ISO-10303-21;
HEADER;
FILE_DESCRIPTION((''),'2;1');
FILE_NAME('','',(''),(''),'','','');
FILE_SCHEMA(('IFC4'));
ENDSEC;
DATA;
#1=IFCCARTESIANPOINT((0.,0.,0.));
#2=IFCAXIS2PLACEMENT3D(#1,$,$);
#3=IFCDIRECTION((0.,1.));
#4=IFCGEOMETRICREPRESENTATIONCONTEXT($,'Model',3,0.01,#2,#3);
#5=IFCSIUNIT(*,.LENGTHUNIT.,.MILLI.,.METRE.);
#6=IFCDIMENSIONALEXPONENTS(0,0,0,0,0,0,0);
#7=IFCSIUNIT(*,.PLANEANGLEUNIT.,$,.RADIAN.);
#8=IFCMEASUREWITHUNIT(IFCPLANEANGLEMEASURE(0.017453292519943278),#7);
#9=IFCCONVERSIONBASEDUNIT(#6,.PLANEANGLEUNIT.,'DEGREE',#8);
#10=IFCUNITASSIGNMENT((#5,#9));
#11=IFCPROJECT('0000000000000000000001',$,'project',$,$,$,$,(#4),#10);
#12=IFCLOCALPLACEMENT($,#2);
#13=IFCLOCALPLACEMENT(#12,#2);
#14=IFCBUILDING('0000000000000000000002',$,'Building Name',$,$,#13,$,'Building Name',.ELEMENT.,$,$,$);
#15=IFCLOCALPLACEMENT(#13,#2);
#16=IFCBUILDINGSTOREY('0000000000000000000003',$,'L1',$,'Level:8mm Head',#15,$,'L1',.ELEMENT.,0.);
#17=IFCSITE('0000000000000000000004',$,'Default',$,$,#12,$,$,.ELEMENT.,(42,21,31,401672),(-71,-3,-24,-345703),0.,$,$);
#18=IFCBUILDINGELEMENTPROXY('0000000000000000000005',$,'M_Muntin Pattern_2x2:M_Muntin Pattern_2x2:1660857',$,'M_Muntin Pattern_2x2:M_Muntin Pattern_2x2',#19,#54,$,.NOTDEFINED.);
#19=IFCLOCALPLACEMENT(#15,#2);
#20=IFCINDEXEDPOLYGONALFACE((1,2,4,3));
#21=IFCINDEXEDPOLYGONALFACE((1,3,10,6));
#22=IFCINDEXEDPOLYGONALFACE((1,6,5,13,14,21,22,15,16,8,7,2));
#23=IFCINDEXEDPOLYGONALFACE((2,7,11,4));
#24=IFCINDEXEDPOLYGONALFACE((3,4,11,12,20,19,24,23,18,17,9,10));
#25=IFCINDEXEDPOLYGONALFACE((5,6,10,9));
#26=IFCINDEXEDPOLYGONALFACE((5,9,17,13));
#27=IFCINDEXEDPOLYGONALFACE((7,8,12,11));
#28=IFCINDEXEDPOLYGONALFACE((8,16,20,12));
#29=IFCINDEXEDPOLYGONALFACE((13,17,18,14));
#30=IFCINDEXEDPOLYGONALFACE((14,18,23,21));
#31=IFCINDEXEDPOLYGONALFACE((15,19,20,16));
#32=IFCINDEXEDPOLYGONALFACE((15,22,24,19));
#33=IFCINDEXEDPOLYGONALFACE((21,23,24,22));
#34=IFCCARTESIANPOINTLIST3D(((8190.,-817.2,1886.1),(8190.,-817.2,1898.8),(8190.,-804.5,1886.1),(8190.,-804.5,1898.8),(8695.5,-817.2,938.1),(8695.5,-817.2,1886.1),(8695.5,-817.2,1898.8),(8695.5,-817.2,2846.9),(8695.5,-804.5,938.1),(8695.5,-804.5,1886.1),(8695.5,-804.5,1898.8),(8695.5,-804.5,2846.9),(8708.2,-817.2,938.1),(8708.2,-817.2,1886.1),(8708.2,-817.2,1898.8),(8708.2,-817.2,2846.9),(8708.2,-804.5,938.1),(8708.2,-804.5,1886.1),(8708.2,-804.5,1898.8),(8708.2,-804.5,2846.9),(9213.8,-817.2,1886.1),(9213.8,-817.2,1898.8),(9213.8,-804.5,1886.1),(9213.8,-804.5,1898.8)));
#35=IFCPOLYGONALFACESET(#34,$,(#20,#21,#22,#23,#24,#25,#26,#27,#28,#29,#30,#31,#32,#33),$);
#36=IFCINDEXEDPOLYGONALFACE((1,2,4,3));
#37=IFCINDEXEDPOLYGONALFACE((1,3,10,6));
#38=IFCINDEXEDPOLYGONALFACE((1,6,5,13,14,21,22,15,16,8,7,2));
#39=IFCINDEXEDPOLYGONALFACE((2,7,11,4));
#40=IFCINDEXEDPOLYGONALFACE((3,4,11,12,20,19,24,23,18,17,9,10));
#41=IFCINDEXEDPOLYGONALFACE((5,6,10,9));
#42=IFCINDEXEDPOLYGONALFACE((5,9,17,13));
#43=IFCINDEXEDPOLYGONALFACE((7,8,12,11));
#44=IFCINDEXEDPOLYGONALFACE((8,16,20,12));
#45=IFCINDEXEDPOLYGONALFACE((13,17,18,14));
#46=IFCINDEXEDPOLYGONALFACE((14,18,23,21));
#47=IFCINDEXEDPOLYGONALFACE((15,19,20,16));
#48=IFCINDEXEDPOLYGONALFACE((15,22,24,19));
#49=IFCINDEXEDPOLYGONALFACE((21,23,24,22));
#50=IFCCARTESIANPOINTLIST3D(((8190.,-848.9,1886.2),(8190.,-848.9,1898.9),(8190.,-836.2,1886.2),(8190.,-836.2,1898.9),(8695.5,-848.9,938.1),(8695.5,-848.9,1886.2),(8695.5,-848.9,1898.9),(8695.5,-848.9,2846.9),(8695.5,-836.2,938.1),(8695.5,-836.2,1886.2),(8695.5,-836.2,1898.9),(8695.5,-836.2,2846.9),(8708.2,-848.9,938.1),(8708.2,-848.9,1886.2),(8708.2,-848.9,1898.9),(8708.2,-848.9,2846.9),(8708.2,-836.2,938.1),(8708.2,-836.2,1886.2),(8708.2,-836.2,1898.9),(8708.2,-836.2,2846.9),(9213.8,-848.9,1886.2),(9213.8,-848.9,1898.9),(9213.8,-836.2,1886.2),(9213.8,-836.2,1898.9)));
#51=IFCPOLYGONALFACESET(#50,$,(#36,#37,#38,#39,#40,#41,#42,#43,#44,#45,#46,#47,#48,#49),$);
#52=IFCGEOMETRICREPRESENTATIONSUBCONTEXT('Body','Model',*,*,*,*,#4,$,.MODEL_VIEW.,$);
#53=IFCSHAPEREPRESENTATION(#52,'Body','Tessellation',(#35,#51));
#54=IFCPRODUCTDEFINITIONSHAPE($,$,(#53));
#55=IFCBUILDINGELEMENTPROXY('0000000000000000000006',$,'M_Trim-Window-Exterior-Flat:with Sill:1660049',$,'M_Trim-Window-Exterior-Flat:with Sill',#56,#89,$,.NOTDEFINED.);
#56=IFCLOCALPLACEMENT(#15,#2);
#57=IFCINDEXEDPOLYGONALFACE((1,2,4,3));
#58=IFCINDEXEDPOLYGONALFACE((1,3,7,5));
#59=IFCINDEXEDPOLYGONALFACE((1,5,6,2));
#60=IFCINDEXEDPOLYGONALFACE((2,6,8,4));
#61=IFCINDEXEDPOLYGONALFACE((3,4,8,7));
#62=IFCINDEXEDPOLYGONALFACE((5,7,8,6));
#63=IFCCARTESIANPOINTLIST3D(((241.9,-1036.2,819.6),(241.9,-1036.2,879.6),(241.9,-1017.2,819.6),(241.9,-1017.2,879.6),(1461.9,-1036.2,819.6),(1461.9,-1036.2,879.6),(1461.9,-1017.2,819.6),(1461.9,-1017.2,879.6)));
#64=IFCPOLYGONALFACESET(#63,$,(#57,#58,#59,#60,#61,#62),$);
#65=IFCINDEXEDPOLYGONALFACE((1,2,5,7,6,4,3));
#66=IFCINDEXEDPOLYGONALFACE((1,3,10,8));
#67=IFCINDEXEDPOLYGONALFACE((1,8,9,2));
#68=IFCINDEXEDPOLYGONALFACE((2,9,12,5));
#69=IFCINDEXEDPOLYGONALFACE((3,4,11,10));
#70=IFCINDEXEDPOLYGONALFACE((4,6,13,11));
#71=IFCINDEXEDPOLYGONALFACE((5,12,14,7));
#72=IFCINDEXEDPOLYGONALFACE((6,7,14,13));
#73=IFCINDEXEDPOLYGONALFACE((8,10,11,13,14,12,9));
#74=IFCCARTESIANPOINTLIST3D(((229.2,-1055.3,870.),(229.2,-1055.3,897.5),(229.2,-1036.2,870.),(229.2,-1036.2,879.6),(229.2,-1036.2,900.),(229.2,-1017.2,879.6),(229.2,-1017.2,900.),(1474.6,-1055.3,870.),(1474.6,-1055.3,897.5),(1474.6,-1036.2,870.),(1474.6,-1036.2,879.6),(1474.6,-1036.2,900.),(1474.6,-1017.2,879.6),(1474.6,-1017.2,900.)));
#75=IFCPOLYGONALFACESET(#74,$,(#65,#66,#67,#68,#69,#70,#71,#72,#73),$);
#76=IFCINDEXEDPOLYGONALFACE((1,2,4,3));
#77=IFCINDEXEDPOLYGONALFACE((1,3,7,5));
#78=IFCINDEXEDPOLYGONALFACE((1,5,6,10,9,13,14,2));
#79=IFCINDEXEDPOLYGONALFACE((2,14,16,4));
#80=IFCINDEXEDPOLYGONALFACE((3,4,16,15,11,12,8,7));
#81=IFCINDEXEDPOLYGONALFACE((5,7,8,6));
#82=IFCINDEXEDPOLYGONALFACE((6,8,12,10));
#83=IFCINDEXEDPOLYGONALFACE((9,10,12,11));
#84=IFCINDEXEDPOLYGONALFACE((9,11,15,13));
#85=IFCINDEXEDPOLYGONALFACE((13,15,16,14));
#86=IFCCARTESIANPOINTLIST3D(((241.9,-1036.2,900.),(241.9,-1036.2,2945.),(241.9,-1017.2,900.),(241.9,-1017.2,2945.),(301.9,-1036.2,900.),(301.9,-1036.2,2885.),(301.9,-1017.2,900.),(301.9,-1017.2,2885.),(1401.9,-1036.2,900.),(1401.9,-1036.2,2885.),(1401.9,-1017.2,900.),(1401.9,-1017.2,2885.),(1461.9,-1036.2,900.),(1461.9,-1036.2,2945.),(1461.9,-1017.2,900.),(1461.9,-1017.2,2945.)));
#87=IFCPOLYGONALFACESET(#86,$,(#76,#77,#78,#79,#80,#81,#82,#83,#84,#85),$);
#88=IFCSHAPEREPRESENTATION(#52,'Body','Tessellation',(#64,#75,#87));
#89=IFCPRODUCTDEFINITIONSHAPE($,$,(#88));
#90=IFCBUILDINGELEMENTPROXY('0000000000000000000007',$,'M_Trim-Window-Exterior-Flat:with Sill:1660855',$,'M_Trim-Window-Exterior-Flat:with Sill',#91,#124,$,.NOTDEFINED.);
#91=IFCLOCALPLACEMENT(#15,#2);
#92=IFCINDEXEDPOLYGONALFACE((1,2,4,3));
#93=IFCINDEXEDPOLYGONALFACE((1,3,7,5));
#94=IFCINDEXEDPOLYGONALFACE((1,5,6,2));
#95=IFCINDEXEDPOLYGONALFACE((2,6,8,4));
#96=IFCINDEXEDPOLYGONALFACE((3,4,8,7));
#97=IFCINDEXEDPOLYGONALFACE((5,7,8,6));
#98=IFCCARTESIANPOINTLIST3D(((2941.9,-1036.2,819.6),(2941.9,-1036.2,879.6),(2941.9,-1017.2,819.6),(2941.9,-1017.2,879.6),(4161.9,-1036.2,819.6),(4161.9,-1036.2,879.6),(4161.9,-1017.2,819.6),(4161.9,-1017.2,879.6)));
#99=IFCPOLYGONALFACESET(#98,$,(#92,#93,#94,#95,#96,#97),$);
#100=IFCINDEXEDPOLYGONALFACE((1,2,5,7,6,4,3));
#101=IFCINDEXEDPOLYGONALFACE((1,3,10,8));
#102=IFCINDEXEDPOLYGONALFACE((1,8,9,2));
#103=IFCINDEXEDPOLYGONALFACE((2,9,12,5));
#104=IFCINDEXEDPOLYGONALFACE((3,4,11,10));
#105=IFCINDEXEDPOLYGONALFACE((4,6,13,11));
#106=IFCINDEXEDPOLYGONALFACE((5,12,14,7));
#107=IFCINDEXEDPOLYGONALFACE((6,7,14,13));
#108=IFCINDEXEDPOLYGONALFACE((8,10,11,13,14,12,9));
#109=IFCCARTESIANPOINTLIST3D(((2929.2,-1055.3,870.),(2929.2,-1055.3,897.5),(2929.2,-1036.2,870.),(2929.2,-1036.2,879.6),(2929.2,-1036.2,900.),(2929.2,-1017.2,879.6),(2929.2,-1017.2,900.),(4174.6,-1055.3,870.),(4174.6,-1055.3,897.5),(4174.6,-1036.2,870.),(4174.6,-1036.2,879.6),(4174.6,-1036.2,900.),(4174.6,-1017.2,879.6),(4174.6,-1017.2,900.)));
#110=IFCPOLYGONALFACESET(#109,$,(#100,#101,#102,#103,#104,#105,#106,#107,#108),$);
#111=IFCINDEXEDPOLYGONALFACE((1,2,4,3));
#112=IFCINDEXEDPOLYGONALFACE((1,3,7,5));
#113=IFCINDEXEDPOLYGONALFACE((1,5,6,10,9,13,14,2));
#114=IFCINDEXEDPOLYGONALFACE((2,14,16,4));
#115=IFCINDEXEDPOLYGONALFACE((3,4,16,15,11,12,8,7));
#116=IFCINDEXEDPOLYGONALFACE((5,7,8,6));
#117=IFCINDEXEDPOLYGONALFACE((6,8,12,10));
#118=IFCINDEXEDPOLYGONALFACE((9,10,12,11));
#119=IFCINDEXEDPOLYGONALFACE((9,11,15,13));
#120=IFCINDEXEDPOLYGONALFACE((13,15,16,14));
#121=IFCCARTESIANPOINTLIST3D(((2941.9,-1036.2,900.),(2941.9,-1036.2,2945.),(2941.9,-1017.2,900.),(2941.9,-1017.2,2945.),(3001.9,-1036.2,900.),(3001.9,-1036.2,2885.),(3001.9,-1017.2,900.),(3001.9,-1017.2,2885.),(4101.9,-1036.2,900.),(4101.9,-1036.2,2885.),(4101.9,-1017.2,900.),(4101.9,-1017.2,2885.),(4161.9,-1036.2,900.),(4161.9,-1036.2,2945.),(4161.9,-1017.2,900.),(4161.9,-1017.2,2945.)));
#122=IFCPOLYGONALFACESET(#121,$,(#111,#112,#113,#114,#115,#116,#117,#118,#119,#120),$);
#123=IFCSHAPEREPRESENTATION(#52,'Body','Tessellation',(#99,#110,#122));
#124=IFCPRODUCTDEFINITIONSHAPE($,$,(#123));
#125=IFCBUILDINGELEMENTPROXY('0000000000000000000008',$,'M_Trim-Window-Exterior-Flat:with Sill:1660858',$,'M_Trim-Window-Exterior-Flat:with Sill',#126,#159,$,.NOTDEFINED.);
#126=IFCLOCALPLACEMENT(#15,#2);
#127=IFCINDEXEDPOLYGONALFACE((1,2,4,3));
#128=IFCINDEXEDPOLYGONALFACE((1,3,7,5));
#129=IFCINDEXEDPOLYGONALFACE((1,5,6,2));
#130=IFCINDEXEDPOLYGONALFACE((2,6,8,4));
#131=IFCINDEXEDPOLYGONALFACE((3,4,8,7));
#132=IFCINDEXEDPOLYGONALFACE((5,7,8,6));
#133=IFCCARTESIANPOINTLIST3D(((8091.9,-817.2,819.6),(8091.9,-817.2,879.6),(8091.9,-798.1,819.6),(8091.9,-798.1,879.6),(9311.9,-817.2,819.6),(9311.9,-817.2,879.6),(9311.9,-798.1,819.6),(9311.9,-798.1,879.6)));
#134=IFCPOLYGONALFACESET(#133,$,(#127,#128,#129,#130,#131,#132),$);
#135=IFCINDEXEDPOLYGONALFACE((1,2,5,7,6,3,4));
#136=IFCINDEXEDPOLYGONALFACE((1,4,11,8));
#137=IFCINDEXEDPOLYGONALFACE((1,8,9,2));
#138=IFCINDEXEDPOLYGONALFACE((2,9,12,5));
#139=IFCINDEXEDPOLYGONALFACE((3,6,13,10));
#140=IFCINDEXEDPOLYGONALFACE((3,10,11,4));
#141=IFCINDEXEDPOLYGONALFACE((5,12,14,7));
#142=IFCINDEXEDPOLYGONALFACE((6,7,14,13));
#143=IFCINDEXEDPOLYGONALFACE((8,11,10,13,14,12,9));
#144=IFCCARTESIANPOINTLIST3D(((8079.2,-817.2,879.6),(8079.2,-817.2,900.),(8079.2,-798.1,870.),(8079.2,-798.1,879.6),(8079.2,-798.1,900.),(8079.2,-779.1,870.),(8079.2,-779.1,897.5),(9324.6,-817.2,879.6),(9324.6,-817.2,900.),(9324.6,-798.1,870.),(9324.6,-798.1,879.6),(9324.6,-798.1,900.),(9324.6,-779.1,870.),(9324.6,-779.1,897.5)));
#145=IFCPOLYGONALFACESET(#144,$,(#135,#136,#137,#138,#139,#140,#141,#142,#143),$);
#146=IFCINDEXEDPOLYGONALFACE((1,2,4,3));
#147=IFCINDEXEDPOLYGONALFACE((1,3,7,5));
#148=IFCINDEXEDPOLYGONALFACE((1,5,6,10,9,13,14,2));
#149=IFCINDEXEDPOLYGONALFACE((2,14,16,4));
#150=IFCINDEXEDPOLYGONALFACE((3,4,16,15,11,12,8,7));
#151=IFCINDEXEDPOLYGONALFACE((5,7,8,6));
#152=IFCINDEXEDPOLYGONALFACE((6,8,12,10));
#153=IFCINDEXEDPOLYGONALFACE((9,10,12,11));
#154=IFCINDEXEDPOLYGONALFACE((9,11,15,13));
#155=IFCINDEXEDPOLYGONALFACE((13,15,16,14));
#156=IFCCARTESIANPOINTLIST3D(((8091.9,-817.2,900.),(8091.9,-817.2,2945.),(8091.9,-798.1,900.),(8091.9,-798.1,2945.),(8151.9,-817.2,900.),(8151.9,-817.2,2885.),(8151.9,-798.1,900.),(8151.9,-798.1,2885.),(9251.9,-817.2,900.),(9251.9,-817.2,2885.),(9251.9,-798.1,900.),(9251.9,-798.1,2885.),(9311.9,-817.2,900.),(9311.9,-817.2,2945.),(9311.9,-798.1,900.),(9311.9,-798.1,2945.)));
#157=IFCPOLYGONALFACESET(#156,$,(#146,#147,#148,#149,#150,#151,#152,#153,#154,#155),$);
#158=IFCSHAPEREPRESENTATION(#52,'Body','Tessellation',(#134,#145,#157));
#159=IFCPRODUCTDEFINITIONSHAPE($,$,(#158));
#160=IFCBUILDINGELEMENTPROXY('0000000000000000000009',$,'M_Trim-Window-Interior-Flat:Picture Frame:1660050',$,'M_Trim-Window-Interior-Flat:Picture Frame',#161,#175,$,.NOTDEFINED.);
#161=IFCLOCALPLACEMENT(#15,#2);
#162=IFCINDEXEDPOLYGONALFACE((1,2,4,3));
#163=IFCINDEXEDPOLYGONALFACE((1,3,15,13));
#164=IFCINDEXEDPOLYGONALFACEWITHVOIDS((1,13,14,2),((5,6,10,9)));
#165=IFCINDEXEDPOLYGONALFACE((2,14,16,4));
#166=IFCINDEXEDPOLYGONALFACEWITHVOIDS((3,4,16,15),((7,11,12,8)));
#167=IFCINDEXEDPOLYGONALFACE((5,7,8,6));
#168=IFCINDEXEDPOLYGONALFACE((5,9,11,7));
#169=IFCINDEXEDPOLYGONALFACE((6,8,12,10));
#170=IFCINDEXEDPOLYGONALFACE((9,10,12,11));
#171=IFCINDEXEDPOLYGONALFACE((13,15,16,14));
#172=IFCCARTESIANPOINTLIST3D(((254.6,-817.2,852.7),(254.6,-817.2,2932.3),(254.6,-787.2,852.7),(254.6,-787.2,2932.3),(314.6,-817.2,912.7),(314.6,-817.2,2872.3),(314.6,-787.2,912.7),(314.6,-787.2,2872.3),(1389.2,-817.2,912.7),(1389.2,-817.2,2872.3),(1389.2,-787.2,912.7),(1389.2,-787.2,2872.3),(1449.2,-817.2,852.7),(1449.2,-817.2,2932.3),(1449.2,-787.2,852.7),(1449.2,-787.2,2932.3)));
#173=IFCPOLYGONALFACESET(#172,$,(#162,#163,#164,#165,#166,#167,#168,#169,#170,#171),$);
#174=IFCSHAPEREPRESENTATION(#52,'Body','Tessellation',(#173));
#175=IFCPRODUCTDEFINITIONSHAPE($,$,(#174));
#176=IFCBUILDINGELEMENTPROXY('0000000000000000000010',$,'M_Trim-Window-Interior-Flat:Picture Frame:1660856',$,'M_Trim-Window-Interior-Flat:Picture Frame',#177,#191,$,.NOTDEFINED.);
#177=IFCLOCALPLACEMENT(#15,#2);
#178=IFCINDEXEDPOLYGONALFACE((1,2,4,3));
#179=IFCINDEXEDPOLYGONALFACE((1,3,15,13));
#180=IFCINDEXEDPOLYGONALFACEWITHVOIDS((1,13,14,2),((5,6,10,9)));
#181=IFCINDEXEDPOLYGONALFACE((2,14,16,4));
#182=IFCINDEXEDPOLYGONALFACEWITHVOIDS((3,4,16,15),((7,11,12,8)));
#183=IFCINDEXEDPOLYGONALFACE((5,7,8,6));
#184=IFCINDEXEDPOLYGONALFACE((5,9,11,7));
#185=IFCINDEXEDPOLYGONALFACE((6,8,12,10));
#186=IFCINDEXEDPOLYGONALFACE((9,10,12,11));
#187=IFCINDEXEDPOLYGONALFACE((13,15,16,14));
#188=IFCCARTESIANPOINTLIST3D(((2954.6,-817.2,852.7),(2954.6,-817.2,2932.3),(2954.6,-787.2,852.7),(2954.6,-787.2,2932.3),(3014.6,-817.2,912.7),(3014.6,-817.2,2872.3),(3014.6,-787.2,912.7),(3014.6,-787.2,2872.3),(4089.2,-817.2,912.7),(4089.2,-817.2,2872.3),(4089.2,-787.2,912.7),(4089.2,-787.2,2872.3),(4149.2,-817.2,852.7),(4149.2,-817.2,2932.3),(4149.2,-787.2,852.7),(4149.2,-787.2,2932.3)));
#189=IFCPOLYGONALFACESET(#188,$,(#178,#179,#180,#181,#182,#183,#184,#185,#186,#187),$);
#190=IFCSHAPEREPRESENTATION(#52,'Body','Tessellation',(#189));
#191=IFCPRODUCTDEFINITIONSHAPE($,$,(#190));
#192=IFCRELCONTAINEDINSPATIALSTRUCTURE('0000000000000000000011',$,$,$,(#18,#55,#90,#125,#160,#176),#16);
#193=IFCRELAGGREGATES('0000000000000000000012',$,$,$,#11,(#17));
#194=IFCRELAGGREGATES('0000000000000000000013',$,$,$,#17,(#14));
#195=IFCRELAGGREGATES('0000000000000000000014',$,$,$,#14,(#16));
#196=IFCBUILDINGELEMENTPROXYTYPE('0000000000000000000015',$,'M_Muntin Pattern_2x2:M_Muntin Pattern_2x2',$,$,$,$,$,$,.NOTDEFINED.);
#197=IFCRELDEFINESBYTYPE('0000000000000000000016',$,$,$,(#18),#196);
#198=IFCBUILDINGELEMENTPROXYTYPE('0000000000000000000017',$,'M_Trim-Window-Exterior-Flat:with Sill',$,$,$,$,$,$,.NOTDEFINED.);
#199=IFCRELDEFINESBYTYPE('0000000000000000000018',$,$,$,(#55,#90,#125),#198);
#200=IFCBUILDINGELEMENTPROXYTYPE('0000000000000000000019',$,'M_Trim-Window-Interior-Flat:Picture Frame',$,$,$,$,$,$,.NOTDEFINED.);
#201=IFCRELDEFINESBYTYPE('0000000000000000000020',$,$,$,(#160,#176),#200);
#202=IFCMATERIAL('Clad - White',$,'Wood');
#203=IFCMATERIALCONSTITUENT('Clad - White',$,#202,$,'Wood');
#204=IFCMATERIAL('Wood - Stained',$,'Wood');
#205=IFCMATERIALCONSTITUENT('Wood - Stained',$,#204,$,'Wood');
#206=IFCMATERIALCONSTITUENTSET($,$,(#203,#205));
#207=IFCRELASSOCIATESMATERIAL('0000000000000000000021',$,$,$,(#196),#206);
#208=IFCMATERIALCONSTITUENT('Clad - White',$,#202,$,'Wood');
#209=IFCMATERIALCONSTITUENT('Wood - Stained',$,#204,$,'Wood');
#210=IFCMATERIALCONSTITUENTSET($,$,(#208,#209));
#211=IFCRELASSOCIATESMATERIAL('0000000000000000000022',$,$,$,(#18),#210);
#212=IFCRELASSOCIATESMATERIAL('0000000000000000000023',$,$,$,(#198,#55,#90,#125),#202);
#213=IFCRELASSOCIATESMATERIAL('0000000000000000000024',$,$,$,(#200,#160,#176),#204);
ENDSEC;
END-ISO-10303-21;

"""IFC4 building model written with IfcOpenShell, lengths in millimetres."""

from ifc_helpers import new_model, entity, si_unit, converted_unit, direction, frame, origin, place, context, subcontext, project, spatial, indexed_curve, outline, extrude, source, transform, mapped, material, constituent, constituent_set, type_object, type_shapes, element, save


model = new_model("IFC4")

# Units and contexts
model_context = context("Model", 3, precision=0.01, world=origin(), true_north=direction((0.0, 1.0)))
body_context = subcontext(model_context, "Body", "Model", "MODEL_VIEW")
ifc_project = project(units=[si_unit("LENGTHUNIT", "METRE", prefix="MILLI"), converted_unit("PLANEANGLEUNIT", "DEGREE", entity("IfcPlaneAngleMeasure", 0.017453292519943278), si_unit("PLANEANGLEUNIT", "RADIAN"), dimensions=[0, 0, 0, 0, 0, 0, 0])], contexts=[model_context])

# Site, building, storey
site_placement = place(None, origin())
site = spatial("IfcSite", under=ifc_project, at=site_placement, Name="Default", CompositionType="ELEMENT", RefLatitude=(42, 21, 31, 401672), RefLongitude=(-71, -3, -24, -345703), RefElevation=0.0)
building_placement = place(site_placement, origin())
building = spatial("IfcBuilding", under=site, at=building_placement, Name="Building Name", LongName="Building Name", CompositionType="ELEMENT")
storey_placement = place(building_placement, origin())
storey = spatial("IfcBuildingStorey", under=building, at=storey_placement, Name="L1", ObjectType="Level:8mm Head", LongName="L1", CompositionType="ELEMENT", Elevation=0.0)

# Building element proxies
ifc_material_1 = material(Name="Clad - White", Category="Wood")
ifc_material_2 = material(Name="Wood - Stained", Category="Wood")
ifc_constituent_1 = constituent(ifc_material_1, Name="Clad - White", Category="Wood")
ifc_constituent_2 = constituent(ifc_material_2, Name="Wood - Stained", Category="Wood")
ifc_constituent_set_1 = constituent_set(constituents=[ifc_constituent_1, ifc_constituent_2])
building_element_proxy_type_1 = type_object("IfcBuildingElementProxyType", Name="M_Muntin Pattern_2x2:M_Muntin Pattern_2x2", PredefinedType="NOTDEFINED", material=ifc_constituent_set_1)
shared_shape_1 = source(origin(), body_context, "Body", "SweptSolid", [
    extrude(outline(indexed_curve([(6.4, -6.4), (954.4, -6.4), (954.4, 6.3), (6.4, 6.3), (6.4, 511.9), (-6.3, 511.9), (-6.3, 6.3), (-954.4, 6.3), (-954.4, -6.4), (-6.3, -6.4), (-6.3, -511.9), (6.4, -511.9), (6.4, -6.4)], self_intersect=False)), frame((0.0, -22.2, 954.4), z_axis=(0.0, 1.0, 0.0), x_axis=(0.0, 0.0, 1.0)), (0.0, 0.0, 1.0), 12.7),
    extrude(outline(indexed_curve([(6.4, -6.4), (954.4, -6.4), (954.4, 6.3), (6.4, 6.3), (6.4, 511.9), (-6.3, 511.9), (-6.3, 6.3), (-954.4, 6.3), (-954.4, -6.4), (-6.3, -6.4), (-6.3, -511.9), (6.4, -511.9), (6.4, -6.4)], self_intersect=False)), frame((0.0, 9.5, 954.4), z_axis=(0.0, 1.0, 0.0), x_axis=(0.0, 0.0, 1.0)), (0.0, 0.0, 1.0), 12.7),
])
type_shapes(building_element_proxy_type_1, [shared_shape_1])
ifc_constituent_3 = constituent(ifc_material_1, Name="Clad - White", Category="Wood")
ifc_constituent_4 = constituent(ifc_material_2, Name="Wood - Stained", Category="Wood")
ifc_constituent_set_2 = constituent_set(constituents=[ifc_constituent_3, ifc_constituent_4])
proxy_1_placement = place(storey_placement, frame((8701.9, -826.7, 938.1), z_axis=(0.0, 0.0, 1.0), x_axis=(-1.0, 0.0, 0.0)))
element("IfcBuildingElementProxy", 1, at=proxy_1_placement, inside=storey, type_object=building_element_proxy_type_1, material=ifc_constituent_set_2, Name="M_Muntin Pattern_2x2:M_Muntin Pattern_2x2:1660857", ObjectType="M_Muntin Pattern_2x2:M_Muntin Pattern_2x2", PredefinedType="NOTDEFINED", context=body_context, shape_type="MappedRepresentation", body=[
    mapped(shared_shape_1, transform((0.0, 0.0, 0.0), scale=1.0)),
])
building_element_proxy_type_2 = type_object("IfcBuildingElementProxyType", Name="M_Trim-Window-Exterior-Flat:with Sill", PredefinedType="NOTDEFINED", material=ifc_material_1)
shared_shape_2 = source(origin(), body_context, "Body", "SweptSolid", [
    extrude(outline(indexed_curve([(-610.0, -30.0), (610.0, -30.0), (610.0, 30.0), (-610.0, 30.0), (-610.0, -30.0)], self_intersect=False)), frame((0.0, -2035.4, 0.0), z_axis=(0.0, 0.0, 1.0), x_axis=(-1.0, 0.0, 0.0)), (0.0, 0.0, 1.0), 19.0),
    extrude(outline(indexed_curve([(-19.0, -15.2), (0.0, -15.2), (0.0, -5.7), (19.0, -5.7), (19.0, 14.8), (0.0, 14.8), (-19.0, 12.3), (-19.0, -15.2)], self_intersect=False)), frame((-622.7, -1999.8, 19.0), z_axis=(1.0, 0.0, 0.0), x_axis=(0.0, 0.0, -1.0)), (0.0, 0.0, 1.0), 1245.4),
    extrude(outline(indexed_curve([(-1037.5, -610.0), (1007.5, -610.0), (1007.5, -550.0), (-977.5, -550.0), (-977.5, 550.0), (1007.5, 550.0), (1007.5, 610.0), (-1037.5, 610.0), (-1037.5, -610.0)], self_intersect=False)), frame((0.0, -977.5, 0.0), z_axis=(0.0, 0.0, 1.0), x_axis=(0.0, -1.0, 0.0)), (0.0, 0.0, 1.0), 19.0),
])
type_shapes(building_element_proxy_type_2, [shared_shape_2])
for number, where, z_axis, x_axis, name in (
    (2, (851.9, -1017.2, 2885.0), (0.0, -1.0, 0.0), (1.0, 0.0, 0.0), "M_Trim-Window-Exterior-Flat:with Sill:1660049"),
    (3, (3551.9, -1017.2, 2885.0), (0.0, -1.0, 0.0), (1.0, 0.0, 0.0), "M_Trim-Window-Exterior-Flat:with Sill:1660855"),
    (4, (8701.9, -817.2, 2885.0), (0.0, 1.0, 0.0), (-1.0, 0.0, 0.0), "M_Trim-Window-Exterior-Flat:with Sill:1660858"),
):
    element("IfcBuildingElementProxy", number, at=place(storey_placement, frame(where, z_axis=z_axis, x_axis=x_axis)), inside=storey, type_object=building_element_proxy_type_2, material=ifc_material_1, Name=name, ObjectType="M_Trim-Window-Exterior-Flat:with Sill", PredefinedType="NOTDEFINED", context=body_context, shape_type="MappedRepresentation", body=[
        mapped(shared_shape_2, transform((0.0, 0.0, 0.0), scale=1.0)),
    ])
building_element_proxy_type_3 = type_object("IfcBuildingElementProxyType", Name="M_Trim-Window-Interior-Flat:Picture Frame", PredefinedType="NOTDEFINED", material=ifc_material_2)
shared_shape_3 = source(origin(), body_context, "Body", "SweptSolid", [
    extrude(outline(indexed_curve([(-597.3, -1039.8), (597.3, -1039.8), (597.3, 1039.8), (-597.3, 1039.8), (-597.3, -1039.8)], self_intersect=False), holes=[indexed_curve([(-537.3, -979.8), (-537.3, 979.8), (537.3, 979.8), (537.3, -979.8), (-537.3, -979.8)], self_intersect=False)]), frame((0.0, -992.5, 0.0), z_axis=(0.0, 0.0, 1.0), x_axis=(-1.0, 0.0, 0.0)), (0.0, 0.0, 1.0), 30.0),
])
type_shapes(building_element_proxy_type_3, [shared_shape_3])
for number, where, z_axis, x_axis, name in (
    (5, (851.9, -817.2, 2885.0), (0.0, 1.0, 0.0), (-1.0, 0.0, 0.0), "M_Trim-Window-Interior-Flat:Picture Frame:1660050"),
    (6, (3551.9, -817.2, 2885.0), (0.0, 1.0, 0.0), (-1.0, 0.0, 0.0), "M_Trim-Window-Interior-Flat:Picture Frame:1660856"),
):
    element("IfcBuildingElementProxy", number, at=place(storey_placement, frame(where, z_axis=z_axis, x_axis=x_axis)), inside=storey, type_object=building_element_proxy_type_3, material=ifc_material_2, Name=name, ObjectType="M_Trim-Window-Interior-Flat:Picture Frame", PredefinedType="NOTDEFINED", context=body_context, shape_type="MappedRepresentation", body=[
        mapped(shared_shape_3, transform((0.0, 0.0, 0.0), scale=1.0)),
    ])

save(model, "model.ifc")
